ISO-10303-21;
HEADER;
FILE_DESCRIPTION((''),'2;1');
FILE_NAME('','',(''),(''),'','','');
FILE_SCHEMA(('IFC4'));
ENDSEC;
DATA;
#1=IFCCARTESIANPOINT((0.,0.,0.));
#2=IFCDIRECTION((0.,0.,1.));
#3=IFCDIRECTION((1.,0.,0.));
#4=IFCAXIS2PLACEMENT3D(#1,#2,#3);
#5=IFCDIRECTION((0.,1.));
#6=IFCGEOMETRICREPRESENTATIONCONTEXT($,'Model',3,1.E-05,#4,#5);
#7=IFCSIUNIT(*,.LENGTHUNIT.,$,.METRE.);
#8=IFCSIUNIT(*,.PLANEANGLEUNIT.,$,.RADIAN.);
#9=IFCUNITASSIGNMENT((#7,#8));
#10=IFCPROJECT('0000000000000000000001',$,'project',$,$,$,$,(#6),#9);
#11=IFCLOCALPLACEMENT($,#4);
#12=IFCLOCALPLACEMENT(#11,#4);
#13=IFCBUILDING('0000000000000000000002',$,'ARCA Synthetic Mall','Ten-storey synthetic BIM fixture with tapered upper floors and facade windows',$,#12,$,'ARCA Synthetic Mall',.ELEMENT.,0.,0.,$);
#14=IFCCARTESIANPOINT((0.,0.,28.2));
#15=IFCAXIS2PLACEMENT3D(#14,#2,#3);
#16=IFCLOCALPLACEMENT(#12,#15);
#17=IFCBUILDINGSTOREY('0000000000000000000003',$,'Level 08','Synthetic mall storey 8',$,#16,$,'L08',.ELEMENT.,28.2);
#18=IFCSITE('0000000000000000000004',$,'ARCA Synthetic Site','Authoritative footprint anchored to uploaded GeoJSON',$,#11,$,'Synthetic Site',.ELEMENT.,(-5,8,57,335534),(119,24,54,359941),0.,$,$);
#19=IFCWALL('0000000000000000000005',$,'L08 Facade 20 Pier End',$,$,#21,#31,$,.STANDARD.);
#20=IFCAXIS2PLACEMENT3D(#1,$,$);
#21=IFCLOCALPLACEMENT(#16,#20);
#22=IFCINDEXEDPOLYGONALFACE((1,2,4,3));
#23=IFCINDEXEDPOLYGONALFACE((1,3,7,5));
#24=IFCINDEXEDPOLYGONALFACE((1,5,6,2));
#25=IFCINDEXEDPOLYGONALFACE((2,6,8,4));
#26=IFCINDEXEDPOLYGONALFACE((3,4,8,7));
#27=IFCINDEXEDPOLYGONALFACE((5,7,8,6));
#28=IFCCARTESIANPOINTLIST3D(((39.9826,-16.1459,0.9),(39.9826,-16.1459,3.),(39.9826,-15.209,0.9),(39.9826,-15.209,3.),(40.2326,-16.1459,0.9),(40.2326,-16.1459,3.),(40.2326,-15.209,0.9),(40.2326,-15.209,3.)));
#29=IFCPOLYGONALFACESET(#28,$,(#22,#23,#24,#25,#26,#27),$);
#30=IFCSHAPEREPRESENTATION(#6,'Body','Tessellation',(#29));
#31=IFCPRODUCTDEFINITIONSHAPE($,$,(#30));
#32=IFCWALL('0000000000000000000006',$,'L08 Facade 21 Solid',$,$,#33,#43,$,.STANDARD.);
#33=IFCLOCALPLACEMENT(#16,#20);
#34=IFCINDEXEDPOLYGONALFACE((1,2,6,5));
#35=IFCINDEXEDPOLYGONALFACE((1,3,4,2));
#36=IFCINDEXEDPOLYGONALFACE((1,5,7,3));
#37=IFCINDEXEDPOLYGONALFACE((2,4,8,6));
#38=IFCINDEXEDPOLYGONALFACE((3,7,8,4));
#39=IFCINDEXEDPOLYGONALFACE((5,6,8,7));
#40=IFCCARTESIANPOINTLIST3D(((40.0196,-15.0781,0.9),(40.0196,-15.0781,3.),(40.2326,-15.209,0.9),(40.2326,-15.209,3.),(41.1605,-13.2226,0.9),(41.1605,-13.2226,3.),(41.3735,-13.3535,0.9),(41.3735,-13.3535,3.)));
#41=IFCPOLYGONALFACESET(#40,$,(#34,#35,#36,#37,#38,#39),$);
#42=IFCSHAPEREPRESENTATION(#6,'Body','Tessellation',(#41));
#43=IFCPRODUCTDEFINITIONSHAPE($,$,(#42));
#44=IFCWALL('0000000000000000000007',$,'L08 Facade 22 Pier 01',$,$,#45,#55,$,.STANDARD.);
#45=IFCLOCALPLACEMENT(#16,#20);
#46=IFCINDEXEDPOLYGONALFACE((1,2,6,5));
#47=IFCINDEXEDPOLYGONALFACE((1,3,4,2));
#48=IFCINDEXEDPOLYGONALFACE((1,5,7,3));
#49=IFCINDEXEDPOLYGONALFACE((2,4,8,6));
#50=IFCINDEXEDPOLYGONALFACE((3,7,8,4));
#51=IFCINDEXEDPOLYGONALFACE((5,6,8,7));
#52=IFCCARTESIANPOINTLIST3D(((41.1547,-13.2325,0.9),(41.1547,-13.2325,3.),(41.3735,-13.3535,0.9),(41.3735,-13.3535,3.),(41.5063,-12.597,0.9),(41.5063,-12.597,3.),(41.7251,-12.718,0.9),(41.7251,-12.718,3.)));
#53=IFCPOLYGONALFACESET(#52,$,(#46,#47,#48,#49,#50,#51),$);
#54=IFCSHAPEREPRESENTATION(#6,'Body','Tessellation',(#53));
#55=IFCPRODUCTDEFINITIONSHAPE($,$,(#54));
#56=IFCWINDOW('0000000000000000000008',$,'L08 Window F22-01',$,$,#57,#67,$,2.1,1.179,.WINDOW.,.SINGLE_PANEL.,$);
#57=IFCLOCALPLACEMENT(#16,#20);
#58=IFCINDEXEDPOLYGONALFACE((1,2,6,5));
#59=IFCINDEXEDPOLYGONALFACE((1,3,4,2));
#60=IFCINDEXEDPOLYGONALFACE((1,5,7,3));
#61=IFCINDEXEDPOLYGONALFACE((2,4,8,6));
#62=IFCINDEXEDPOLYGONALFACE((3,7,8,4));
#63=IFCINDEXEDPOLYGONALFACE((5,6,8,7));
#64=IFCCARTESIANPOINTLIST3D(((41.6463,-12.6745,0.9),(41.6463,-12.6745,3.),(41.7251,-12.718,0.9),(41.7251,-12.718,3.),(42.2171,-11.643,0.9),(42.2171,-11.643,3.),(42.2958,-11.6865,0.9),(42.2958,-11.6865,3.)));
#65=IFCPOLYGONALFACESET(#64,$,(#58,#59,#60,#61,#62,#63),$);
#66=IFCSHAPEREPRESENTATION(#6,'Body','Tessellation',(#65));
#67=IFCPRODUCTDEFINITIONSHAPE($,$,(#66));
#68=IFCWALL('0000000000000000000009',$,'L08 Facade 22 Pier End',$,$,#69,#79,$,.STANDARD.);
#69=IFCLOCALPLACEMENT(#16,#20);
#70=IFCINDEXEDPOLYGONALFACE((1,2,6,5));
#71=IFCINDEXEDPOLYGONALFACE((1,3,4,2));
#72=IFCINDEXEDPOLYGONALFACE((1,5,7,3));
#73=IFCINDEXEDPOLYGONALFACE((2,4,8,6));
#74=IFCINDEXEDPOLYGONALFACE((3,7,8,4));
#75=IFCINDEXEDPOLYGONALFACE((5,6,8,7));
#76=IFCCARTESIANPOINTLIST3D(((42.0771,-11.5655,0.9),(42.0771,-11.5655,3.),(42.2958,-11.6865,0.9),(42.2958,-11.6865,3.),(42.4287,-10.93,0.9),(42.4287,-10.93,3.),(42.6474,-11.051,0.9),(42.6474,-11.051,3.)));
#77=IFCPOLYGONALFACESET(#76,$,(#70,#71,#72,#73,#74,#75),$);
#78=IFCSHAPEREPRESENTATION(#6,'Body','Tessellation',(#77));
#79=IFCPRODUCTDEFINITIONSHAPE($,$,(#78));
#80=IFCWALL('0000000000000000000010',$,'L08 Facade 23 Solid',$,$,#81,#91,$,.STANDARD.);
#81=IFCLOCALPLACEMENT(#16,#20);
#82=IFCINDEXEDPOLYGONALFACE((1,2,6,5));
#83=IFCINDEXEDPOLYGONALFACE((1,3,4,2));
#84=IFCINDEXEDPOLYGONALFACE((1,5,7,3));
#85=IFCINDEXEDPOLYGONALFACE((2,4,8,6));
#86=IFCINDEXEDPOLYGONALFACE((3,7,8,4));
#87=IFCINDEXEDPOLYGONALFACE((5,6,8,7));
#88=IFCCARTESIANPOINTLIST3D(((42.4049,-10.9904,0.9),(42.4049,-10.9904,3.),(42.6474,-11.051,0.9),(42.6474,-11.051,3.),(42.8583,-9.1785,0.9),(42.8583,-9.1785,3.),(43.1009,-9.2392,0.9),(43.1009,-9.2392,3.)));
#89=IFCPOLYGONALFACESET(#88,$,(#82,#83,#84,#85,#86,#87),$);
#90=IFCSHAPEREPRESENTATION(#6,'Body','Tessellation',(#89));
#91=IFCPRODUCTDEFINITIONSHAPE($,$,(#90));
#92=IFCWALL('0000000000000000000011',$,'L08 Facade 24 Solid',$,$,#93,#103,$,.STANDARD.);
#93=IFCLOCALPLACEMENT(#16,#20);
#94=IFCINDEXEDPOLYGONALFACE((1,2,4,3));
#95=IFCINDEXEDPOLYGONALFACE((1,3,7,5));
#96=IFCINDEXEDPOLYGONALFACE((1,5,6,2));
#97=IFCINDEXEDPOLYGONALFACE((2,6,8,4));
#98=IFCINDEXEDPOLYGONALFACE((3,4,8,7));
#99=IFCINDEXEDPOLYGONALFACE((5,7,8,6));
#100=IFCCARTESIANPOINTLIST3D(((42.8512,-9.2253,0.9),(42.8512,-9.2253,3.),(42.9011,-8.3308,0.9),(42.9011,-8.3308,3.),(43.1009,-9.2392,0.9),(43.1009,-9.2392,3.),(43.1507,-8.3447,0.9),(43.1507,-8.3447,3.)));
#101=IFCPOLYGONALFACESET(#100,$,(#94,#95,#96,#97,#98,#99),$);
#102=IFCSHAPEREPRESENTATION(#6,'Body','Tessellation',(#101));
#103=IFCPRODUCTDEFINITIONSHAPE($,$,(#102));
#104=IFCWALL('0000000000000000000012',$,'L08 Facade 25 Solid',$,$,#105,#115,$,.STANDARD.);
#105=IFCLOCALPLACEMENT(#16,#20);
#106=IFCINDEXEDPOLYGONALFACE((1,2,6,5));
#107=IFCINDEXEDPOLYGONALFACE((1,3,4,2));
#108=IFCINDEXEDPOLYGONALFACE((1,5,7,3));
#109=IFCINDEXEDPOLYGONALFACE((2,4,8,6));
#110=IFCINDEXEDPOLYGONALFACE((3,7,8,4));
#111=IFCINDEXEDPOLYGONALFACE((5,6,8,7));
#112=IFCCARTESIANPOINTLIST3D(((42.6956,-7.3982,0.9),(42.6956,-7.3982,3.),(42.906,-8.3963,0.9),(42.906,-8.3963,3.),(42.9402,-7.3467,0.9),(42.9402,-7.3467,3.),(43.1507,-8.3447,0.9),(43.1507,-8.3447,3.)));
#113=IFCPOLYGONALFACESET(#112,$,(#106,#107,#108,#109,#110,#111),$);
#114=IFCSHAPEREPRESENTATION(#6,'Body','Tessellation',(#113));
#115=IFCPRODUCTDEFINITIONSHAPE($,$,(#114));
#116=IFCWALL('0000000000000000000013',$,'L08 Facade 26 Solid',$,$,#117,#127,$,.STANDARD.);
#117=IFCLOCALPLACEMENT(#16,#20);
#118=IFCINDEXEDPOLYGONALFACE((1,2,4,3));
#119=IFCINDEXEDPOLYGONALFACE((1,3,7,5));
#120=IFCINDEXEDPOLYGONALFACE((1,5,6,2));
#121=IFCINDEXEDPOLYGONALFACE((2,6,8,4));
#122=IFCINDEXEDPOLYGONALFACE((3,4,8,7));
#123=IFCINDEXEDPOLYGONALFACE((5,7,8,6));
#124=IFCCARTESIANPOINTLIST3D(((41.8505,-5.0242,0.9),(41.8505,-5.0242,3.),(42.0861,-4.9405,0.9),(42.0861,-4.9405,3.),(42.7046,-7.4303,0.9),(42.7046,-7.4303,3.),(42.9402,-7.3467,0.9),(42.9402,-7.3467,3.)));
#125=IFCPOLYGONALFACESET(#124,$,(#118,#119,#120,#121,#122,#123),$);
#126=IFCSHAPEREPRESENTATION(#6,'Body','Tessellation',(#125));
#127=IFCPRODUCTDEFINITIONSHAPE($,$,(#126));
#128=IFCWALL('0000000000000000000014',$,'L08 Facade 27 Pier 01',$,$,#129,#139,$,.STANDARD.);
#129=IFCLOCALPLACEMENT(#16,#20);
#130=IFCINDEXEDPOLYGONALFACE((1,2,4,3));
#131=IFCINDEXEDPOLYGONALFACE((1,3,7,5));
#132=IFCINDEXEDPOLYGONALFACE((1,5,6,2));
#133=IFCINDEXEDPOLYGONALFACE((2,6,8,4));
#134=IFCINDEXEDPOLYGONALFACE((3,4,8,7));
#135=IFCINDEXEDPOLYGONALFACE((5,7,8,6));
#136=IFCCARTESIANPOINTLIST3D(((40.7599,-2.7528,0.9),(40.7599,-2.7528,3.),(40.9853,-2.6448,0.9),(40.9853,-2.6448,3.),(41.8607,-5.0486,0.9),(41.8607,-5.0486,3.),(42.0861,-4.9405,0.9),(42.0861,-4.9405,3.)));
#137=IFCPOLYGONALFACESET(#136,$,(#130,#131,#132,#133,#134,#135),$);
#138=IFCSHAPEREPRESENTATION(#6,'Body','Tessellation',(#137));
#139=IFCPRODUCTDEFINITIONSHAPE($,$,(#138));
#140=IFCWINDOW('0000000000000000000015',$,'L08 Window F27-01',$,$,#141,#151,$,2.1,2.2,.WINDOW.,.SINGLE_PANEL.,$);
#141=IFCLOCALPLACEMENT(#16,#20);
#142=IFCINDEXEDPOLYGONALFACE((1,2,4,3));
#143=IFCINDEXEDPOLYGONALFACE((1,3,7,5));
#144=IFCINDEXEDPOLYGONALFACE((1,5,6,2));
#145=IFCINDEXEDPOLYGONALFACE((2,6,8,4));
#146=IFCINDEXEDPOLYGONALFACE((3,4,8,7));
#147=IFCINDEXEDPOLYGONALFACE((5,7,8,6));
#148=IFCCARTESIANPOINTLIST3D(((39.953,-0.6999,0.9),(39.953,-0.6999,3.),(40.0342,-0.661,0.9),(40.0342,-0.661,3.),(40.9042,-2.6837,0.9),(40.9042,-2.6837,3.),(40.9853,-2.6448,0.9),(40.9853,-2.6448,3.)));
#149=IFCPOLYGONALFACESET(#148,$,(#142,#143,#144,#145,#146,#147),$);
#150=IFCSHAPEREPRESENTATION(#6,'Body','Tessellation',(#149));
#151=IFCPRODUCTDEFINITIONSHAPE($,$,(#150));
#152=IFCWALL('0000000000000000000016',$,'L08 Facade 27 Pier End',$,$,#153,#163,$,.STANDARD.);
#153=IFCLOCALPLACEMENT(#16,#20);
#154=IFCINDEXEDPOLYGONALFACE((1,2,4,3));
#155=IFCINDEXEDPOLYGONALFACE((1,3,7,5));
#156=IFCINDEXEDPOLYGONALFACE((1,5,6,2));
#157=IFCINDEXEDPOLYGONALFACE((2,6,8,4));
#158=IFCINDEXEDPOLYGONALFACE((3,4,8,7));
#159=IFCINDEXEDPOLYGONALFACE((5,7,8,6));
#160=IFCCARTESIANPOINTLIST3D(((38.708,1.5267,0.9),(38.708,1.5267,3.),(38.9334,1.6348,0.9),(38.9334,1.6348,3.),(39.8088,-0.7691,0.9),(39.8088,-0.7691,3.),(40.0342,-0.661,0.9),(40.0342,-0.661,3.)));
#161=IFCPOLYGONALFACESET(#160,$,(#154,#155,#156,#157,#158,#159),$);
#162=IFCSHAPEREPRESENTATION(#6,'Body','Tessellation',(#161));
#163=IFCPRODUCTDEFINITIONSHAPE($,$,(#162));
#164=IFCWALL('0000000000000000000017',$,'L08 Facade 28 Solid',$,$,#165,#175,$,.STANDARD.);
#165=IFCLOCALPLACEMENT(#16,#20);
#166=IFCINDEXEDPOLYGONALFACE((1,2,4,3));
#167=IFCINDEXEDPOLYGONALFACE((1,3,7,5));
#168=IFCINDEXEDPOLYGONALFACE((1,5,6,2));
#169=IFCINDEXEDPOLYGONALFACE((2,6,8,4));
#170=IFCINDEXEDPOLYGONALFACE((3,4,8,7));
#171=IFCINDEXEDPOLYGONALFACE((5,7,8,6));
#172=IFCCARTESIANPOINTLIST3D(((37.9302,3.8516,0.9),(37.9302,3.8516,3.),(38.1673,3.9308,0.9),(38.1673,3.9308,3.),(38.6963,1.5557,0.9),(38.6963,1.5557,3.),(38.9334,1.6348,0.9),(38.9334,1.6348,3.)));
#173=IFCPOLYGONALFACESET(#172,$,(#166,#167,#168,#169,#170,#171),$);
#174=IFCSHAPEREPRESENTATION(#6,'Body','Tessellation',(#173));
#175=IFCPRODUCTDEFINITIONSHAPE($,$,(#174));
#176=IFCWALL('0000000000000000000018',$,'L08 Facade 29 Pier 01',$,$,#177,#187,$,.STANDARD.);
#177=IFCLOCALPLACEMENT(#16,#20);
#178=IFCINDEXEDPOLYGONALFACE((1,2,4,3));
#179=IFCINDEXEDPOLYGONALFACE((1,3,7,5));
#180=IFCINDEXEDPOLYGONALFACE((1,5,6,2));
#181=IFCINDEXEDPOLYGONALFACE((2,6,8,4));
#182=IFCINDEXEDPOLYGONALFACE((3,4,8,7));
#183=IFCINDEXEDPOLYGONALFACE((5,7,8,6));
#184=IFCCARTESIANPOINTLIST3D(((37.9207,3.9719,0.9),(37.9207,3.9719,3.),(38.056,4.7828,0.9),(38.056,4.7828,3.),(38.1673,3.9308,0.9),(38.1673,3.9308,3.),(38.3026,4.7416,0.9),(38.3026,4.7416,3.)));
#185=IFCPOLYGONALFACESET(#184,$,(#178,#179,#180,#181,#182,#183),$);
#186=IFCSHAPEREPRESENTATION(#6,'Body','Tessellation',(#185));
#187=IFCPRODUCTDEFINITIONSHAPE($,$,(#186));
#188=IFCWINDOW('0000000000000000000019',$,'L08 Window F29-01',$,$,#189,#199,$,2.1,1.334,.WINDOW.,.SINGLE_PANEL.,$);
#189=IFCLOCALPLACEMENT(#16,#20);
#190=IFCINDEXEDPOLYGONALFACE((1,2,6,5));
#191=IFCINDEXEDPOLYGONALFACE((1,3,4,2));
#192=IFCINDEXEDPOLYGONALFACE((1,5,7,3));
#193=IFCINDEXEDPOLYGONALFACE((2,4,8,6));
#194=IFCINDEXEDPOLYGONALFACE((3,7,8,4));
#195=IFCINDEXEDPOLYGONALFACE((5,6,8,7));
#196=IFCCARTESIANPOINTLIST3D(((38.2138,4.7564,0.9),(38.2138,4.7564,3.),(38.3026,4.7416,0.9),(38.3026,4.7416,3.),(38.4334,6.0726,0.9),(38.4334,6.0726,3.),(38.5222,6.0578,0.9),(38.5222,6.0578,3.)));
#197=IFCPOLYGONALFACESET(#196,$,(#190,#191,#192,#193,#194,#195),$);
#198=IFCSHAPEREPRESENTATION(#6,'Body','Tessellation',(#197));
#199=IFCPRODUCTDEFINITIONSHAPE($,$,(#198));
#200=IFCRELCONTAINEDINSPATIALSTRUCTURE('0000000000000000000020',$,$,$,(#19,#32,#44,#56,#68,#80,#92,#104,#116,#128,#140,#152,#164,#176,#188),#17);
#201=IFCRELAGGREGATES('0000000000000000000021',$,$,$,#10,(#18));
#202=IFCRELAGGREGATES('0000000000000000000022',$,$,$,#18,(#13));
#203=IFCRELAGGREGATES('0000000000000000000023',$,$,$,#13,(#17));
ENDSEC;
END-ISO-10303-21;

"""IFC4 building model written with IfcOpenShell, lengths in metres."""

from ifc_helpers import new_model, si_unit, direction, frame, origin_with_axes, place, context, project, spatial, polyline, outline, extrude, element, save


model = new_model("IFC4")

# Units and contexts
model_context = context("Model", 3, precision=1e-05, world=origin_with_axes(), true_north=direction((0.0, 1.0)))
ifc_project = project(units=[si_unit("LENGTHUNIT", "METRE"), si_unit("PLANEANGLEUNIT", "RADIAN")], contexts=[model_context])

# Site, building, storey
site_placement = place(None, origin_with_axes())
site = spatial("IfcSite", under=ifc_project, at=site_placement, Name="ARCA Synthetic Site", Description="Authoritative footprint anchored to uploaded GeoJSON", LongName="Synthetic Site", CompositionType="ELEMENT", RefLatitude=(-5, 8, 57, 335534), RefLongitude=(119, 24, 54, 359941), RefElevation=0.0)
building_placement = place(site_placement, origin_with_axes())
building = spatial("IfcBuilding", under=site, at=building_placement, Name="ARCA Synthetic Mall", Description="Ten-storey synthetic BIM fixture with tapered upper floors and facade windows", LongName="ARCA Synthetic Mall", CompositionType="ELEMENT", ElevationOfRefHeight=0.0, ElevationOfTerrain=0.0)
storey_placement = place(building_placement, frame((0.0, 0.0, 28.2), z_axis=(0.0, 0.0, 1.0), x_axis=(1.0, 0.0, 0.0)))
storey = spatial("IfcBuildingStorey", under=building, at=storey_placement, Name="Level 08", Description="Synthetic mall storey 8", LongName="L08", CompositionType="ELEMENT", Elevation=28.2)

# Walls
wall_1_placement = place(storey_placement, frame((0.0, 0.0, 0.9), z_axis=(0.0, 0.0, 1.0), x_axis=(1.0, 0.0, 0.0)))
element("IfcWall", 1, at=wall_1_placement, inside=storey, Name="L08 Facade 20 Pier End", PredefinedType="STANDARD", context=model_context, shape_type="SweptSolid", body=[
    extrude(outline(polyline([(40.2326, -16.1459), (40.2326, -15.209), (39.9826, -15.209), (39.9826, -16.1459), (40.2326, -16.1459)])), origin_with_axes(), (0.0, 0.0, 1.0), 2.1),
])
wall_2_placement = place(storey_placement, frame((0.0, 0.0, 0.9), z_axis=(0.0, 0.0, 1.0), x_axis=(1.0, 0.0, 0.0)))
element("IfcWall", 2, at=wall_2_placement, inside=storey, Name="L08 Facade 21 Solid", PredefinedType="STANDARD", context=model_context, shape_type="SweptSolid", body=[
    extrude(outline(polyline([(40.2326, -15.209), (41.3735, -13.3535), (41.1605, -13.2226), (40.0196, -15.0781), (40.2326, -15.209)])), origin_with_axes(), (0.0, 0.0, 1.0), 2.1),
])
wall_3_placement = place(storey_placement, frame((0.0, 0.0, 0.9), z_axis=(0.0, 0.0, 1.0), x_axis=(1.0, 0.0, 0.0)))
element("IfcWall", 3, at=wall_3_placement, inside=storey, Name="L08 Facade 22 Pier 01", PredefinedType="STANDARD", context=model_context, shape_type="SweptSolid", body=[
    extrude(outline(polyline([(41.3735, -13.3535), (41.7251, -12.718), (41.5063, -12.597), (41.1547, -13.2325), (41.3735, -13.3535)])), origin_with_axes(), (0.0, 0.0, 1.0), 2.1),
])

# Window
window_1_placement = place(storey_placement, frame((0.0, 0.0, 0.9), z_axis=(0.0, 0.0, 1.0), x_axis=(1.0, 0.0, 0.0)))
element("IfcWindow", 4, at=window_1_placement, inside=storey, Name="L08 Window F22-01", OverallHeight=2.1, OverallWidth=1.179, PartitioningType="SINGLE_PANEL", PredefinedType="WINDOW", context=model_context, shape_type="SweptSolid", body=[
    extrude(outline(polyline([(41.7251, -12.718), (42.2958, -11.6865), (42.2171, -11.643), (41.6463, -12.6745), (41.7251, -12.718)])), origin_with_axes(), (0.0, 0.0, 1.0), 2.1),
])

# Walls
wall_4_placement = place(storey_placement, frame((0.0, 0.0, 0.9), z_axis=(0.0, 0.0, 1.0), x_axis=(1.0, 0.0, 0.0)))
element("IfcWall", 5, at=wall_4_placement, inside=storey, Name="L08 Facade 22 Pier End", PredefinedType="STANDARD", context=model_context, shape_type="SweptSolid", body=[
    extrude(outline(polyline([(42.2958, -11.6865), (42.6474, -11.051), (42.4287, -10.93), (42.0771, -11.5655), (42.2958, -11.6865)])), origin_with_axes(), (0.0, 0.0, 1.0), 2.1),
])
wall_5_placement = place(storey_placement, frame((0.0, 0.0, 0.9), z_axis=(0.0, 0.0, 1.0), x_axis=(1.0, 0.0, 0.0)))
element("IfcWall", 6, at=wall_5_placement, inside=storey, Name="L08 Facade 23 Solid", PredefinedType="STANDARD", context=model_context, shape_type="SweptSolid", body=[
    extrude(outline(polyline([(42.6474, -11.051), (43.1009, -9.2392), (42.8583, -9.1785), (42.4049, -10.9904), (42.6474, -11.051)])), origin_with_axes(), (0.0, 0.0, 1.0), 2.1),
])
wall_6_placement = place(storey_placement, frame((0.0, 0.0, 0.9), z_axis=(0.0, 0.0, 1.0), x_axis=(1.0, 0.0, 0.0)))
element("IfcWall", 7, at=wall_6_placement, inside=storey, Name="L08 Facade 24 Solid", PredefinedType="STANDARD", context=model_context, shape_type="SweptSolid", body=[
    extrude(outline(polyline([(43.1009, -9.2392), (43.1507, -8.3447), (42.9011, -8.3308), (42.8512, -9.2253), (43.1009, -9.2392)])), origin_with_axes(), (0.0, 0.0, 1.0), 2.1),
])
wall_7_placement = place(storey_placement, frame((0.0, 0.0, 0.9), z_axis=(0.0, 0.0, 1.0), x_axis=(1.0, 0.0, 0.0)))
element("IfcWall", 8, at=wall_7_placement, inside=storey, Name="L08 Facade 25 Solid", PredefinedType="STANDARD", context=model_context, shape_type="SweptSolid", body=[
    extrude(outline(polyline([(43.1507, -8.3447), (42.9402, -7.3467), (42.6956, -7.3982), (42.906, -8.3963), (43.1507, -8.3447)])), origin_with_axes(), (0.0, 0.0, 1.0), 2.1),
])
wall_8_placement = place(storey_placement, frame((0.0, 0.0, 0.9), z_axis=(0.0, 0.0, 1.0), x_axis=(1.0, 0.0, 0.0)))
element("IfcWall", 9, at=wall_8_placement, inside=storey, Name="L08 Facade 26 Solid", PredefinedType="STANDARD", context=model_context, shape_type="SweptSolid", body=[
    extrude(outline(polyline([(42.9402, -7.3467), (42.0861, -4.9405), (41.8505, -5.0242), (42.7046, -7.4303), (42.9402, -7.3467)])), origin_with_axes(), (0.0, 0.0, 1.0), 2.1),
])
wall_9_placement = place(storey_placement, frame((0.0, 0.0, 0.9), z_axis=(0.0, 0.0, 1.0), x_axis=(1.0, 0.0, 0.0)))
element("IfcWall", 10, at=wall_9_placement, inside=storey, Name="L08 Facade 27 Pier 01", PredefinedType="STANDARD", context=model_context, shape_type="SweptSolid", body=[
    extrude(outline(polyline([(42.0861, -4.9405), (40.9853, -2.6448), (40.7599, -2.7528), (41.8607, -5.0486), (42.0861, -4.9405)])), origin_with_axes(), (0.0, 0.0, 1.0), 2.1),
])

# Window
window_2_placement = place(storey_placement, frame((0.0, 0.0, 0.9), z_axis=(0.0, 0.0, 1.0), x_axis=(1.0, 0.0, 0.0)))
element("IfcWindow", 11, at=window_2_placement, inside=storey, Name="L08 Window F27-01", OverallHeight=2.1, OverallWidth=2.2, PartitioningType="SINGLE_PANEL", PredefinedType="WINDOW", context=model_context, shape_type="SweptSolid", body=[
    extrude(outline(polyline([(40.9853, -2.6448), (40.0342, -0.661), (39.953, -0.6999), (40.9042, -2.6837), (40.9853, -2.6448)])), origin_with_axes(), (0.0, 0.0, 1.0), 2.1),
])

# Walls
wall_10_placement = place(storey_placement, frame((0.0, 0.0, 0.9), z_axis=(0.0, 0.0, 1.0), x_axis=(1.0, 0.0, 0.0)))
element("IfcWall", 12, at=wall_10_placement, inside=storey, Name="L08 Facade 27 Pier End", PredefinedType="STANDARD", context=model_context, shape_type="SweptSolid", body=[
    extrude(outline(polyline([(40.0342, -0.661), (38.9334, 1.6348), (38.708, 1.5267), (39.8088, -0.7691), (40.0342, -0.661)])), origin_with_axes(), (0.0, 0.0, 1.0), 2.1),
])
wall_11_placement = place(storey_placement, frame((0.0, 0.0, 0.9), z_axis=(0.0, 0.0, 1.0), x_axis=(1.0, 0.0, 0.0)))
element("IfcWall", 13, at=wall_11_placement, inside=storey, Name="L08 Facade 28 Solid", PredefinedType="STANDARD", context=model_context, shape_type="SweptSolid", body=[
    extrude(outline(polyline([(38.9334, 1.6348), (38.1673, 3.9308), (37.9302, 3.8516), (38.6963, 1.5557), (38.9334, 1.6348)])), origin_with_axes(), (0.0, 0.0, 1.0), 2.1),
])
wall_12_placement = place(storey_placement, frame((0.0, 0.0, 0.9), z_axis=(0.0, 0.0, 1.0), x_axis=(1.0, 0.0, 0.0)))
element("IfcWall", 14, at=wall_12_placement, inside=storey, Name="L08 Facade 29 Pier 01", PredefinedType="STANDARD", context=model_context, shape_type="SweptSolid", body=[
    extrude(outline(polyline([(38.1673, 3.9308), (38.3026, 4.7416), (38.056, 4.7828), (37.9207, 3.9719), (38.1673, 3.9308)])), origin_with_axes(), (0.0, 0.0, 1.0), 2.1),
])

# Window
window_3_placement = place(storey_placement, frame((0.0, 0.0, 0.9), z_axis=(0.0, 0.0, 1.0), x_axis=(1.0, 0.0, 0.0)))
element("IfcWindow", 15, at=window_3_placement, inside=storey, Name="L08 Window F29-01", OverallHeight=2.1, OverallWidth=1.334, PartitioningType="SINGLE_PANEL", PredefinedType="WINDOW", context=model_context, shape_type="SweptSolid", body=[
    extrude(outline(polyline([(38.3026, 4.7416), (38.5222, 6.0578), (38.4334, 6.0726), (38.2138, 4.7564), (38.3026, 4.7416)])), origin_with_axes(), (0.0, 0.0, 1.0), 2.1),
])

save(model, "model.ifc")
